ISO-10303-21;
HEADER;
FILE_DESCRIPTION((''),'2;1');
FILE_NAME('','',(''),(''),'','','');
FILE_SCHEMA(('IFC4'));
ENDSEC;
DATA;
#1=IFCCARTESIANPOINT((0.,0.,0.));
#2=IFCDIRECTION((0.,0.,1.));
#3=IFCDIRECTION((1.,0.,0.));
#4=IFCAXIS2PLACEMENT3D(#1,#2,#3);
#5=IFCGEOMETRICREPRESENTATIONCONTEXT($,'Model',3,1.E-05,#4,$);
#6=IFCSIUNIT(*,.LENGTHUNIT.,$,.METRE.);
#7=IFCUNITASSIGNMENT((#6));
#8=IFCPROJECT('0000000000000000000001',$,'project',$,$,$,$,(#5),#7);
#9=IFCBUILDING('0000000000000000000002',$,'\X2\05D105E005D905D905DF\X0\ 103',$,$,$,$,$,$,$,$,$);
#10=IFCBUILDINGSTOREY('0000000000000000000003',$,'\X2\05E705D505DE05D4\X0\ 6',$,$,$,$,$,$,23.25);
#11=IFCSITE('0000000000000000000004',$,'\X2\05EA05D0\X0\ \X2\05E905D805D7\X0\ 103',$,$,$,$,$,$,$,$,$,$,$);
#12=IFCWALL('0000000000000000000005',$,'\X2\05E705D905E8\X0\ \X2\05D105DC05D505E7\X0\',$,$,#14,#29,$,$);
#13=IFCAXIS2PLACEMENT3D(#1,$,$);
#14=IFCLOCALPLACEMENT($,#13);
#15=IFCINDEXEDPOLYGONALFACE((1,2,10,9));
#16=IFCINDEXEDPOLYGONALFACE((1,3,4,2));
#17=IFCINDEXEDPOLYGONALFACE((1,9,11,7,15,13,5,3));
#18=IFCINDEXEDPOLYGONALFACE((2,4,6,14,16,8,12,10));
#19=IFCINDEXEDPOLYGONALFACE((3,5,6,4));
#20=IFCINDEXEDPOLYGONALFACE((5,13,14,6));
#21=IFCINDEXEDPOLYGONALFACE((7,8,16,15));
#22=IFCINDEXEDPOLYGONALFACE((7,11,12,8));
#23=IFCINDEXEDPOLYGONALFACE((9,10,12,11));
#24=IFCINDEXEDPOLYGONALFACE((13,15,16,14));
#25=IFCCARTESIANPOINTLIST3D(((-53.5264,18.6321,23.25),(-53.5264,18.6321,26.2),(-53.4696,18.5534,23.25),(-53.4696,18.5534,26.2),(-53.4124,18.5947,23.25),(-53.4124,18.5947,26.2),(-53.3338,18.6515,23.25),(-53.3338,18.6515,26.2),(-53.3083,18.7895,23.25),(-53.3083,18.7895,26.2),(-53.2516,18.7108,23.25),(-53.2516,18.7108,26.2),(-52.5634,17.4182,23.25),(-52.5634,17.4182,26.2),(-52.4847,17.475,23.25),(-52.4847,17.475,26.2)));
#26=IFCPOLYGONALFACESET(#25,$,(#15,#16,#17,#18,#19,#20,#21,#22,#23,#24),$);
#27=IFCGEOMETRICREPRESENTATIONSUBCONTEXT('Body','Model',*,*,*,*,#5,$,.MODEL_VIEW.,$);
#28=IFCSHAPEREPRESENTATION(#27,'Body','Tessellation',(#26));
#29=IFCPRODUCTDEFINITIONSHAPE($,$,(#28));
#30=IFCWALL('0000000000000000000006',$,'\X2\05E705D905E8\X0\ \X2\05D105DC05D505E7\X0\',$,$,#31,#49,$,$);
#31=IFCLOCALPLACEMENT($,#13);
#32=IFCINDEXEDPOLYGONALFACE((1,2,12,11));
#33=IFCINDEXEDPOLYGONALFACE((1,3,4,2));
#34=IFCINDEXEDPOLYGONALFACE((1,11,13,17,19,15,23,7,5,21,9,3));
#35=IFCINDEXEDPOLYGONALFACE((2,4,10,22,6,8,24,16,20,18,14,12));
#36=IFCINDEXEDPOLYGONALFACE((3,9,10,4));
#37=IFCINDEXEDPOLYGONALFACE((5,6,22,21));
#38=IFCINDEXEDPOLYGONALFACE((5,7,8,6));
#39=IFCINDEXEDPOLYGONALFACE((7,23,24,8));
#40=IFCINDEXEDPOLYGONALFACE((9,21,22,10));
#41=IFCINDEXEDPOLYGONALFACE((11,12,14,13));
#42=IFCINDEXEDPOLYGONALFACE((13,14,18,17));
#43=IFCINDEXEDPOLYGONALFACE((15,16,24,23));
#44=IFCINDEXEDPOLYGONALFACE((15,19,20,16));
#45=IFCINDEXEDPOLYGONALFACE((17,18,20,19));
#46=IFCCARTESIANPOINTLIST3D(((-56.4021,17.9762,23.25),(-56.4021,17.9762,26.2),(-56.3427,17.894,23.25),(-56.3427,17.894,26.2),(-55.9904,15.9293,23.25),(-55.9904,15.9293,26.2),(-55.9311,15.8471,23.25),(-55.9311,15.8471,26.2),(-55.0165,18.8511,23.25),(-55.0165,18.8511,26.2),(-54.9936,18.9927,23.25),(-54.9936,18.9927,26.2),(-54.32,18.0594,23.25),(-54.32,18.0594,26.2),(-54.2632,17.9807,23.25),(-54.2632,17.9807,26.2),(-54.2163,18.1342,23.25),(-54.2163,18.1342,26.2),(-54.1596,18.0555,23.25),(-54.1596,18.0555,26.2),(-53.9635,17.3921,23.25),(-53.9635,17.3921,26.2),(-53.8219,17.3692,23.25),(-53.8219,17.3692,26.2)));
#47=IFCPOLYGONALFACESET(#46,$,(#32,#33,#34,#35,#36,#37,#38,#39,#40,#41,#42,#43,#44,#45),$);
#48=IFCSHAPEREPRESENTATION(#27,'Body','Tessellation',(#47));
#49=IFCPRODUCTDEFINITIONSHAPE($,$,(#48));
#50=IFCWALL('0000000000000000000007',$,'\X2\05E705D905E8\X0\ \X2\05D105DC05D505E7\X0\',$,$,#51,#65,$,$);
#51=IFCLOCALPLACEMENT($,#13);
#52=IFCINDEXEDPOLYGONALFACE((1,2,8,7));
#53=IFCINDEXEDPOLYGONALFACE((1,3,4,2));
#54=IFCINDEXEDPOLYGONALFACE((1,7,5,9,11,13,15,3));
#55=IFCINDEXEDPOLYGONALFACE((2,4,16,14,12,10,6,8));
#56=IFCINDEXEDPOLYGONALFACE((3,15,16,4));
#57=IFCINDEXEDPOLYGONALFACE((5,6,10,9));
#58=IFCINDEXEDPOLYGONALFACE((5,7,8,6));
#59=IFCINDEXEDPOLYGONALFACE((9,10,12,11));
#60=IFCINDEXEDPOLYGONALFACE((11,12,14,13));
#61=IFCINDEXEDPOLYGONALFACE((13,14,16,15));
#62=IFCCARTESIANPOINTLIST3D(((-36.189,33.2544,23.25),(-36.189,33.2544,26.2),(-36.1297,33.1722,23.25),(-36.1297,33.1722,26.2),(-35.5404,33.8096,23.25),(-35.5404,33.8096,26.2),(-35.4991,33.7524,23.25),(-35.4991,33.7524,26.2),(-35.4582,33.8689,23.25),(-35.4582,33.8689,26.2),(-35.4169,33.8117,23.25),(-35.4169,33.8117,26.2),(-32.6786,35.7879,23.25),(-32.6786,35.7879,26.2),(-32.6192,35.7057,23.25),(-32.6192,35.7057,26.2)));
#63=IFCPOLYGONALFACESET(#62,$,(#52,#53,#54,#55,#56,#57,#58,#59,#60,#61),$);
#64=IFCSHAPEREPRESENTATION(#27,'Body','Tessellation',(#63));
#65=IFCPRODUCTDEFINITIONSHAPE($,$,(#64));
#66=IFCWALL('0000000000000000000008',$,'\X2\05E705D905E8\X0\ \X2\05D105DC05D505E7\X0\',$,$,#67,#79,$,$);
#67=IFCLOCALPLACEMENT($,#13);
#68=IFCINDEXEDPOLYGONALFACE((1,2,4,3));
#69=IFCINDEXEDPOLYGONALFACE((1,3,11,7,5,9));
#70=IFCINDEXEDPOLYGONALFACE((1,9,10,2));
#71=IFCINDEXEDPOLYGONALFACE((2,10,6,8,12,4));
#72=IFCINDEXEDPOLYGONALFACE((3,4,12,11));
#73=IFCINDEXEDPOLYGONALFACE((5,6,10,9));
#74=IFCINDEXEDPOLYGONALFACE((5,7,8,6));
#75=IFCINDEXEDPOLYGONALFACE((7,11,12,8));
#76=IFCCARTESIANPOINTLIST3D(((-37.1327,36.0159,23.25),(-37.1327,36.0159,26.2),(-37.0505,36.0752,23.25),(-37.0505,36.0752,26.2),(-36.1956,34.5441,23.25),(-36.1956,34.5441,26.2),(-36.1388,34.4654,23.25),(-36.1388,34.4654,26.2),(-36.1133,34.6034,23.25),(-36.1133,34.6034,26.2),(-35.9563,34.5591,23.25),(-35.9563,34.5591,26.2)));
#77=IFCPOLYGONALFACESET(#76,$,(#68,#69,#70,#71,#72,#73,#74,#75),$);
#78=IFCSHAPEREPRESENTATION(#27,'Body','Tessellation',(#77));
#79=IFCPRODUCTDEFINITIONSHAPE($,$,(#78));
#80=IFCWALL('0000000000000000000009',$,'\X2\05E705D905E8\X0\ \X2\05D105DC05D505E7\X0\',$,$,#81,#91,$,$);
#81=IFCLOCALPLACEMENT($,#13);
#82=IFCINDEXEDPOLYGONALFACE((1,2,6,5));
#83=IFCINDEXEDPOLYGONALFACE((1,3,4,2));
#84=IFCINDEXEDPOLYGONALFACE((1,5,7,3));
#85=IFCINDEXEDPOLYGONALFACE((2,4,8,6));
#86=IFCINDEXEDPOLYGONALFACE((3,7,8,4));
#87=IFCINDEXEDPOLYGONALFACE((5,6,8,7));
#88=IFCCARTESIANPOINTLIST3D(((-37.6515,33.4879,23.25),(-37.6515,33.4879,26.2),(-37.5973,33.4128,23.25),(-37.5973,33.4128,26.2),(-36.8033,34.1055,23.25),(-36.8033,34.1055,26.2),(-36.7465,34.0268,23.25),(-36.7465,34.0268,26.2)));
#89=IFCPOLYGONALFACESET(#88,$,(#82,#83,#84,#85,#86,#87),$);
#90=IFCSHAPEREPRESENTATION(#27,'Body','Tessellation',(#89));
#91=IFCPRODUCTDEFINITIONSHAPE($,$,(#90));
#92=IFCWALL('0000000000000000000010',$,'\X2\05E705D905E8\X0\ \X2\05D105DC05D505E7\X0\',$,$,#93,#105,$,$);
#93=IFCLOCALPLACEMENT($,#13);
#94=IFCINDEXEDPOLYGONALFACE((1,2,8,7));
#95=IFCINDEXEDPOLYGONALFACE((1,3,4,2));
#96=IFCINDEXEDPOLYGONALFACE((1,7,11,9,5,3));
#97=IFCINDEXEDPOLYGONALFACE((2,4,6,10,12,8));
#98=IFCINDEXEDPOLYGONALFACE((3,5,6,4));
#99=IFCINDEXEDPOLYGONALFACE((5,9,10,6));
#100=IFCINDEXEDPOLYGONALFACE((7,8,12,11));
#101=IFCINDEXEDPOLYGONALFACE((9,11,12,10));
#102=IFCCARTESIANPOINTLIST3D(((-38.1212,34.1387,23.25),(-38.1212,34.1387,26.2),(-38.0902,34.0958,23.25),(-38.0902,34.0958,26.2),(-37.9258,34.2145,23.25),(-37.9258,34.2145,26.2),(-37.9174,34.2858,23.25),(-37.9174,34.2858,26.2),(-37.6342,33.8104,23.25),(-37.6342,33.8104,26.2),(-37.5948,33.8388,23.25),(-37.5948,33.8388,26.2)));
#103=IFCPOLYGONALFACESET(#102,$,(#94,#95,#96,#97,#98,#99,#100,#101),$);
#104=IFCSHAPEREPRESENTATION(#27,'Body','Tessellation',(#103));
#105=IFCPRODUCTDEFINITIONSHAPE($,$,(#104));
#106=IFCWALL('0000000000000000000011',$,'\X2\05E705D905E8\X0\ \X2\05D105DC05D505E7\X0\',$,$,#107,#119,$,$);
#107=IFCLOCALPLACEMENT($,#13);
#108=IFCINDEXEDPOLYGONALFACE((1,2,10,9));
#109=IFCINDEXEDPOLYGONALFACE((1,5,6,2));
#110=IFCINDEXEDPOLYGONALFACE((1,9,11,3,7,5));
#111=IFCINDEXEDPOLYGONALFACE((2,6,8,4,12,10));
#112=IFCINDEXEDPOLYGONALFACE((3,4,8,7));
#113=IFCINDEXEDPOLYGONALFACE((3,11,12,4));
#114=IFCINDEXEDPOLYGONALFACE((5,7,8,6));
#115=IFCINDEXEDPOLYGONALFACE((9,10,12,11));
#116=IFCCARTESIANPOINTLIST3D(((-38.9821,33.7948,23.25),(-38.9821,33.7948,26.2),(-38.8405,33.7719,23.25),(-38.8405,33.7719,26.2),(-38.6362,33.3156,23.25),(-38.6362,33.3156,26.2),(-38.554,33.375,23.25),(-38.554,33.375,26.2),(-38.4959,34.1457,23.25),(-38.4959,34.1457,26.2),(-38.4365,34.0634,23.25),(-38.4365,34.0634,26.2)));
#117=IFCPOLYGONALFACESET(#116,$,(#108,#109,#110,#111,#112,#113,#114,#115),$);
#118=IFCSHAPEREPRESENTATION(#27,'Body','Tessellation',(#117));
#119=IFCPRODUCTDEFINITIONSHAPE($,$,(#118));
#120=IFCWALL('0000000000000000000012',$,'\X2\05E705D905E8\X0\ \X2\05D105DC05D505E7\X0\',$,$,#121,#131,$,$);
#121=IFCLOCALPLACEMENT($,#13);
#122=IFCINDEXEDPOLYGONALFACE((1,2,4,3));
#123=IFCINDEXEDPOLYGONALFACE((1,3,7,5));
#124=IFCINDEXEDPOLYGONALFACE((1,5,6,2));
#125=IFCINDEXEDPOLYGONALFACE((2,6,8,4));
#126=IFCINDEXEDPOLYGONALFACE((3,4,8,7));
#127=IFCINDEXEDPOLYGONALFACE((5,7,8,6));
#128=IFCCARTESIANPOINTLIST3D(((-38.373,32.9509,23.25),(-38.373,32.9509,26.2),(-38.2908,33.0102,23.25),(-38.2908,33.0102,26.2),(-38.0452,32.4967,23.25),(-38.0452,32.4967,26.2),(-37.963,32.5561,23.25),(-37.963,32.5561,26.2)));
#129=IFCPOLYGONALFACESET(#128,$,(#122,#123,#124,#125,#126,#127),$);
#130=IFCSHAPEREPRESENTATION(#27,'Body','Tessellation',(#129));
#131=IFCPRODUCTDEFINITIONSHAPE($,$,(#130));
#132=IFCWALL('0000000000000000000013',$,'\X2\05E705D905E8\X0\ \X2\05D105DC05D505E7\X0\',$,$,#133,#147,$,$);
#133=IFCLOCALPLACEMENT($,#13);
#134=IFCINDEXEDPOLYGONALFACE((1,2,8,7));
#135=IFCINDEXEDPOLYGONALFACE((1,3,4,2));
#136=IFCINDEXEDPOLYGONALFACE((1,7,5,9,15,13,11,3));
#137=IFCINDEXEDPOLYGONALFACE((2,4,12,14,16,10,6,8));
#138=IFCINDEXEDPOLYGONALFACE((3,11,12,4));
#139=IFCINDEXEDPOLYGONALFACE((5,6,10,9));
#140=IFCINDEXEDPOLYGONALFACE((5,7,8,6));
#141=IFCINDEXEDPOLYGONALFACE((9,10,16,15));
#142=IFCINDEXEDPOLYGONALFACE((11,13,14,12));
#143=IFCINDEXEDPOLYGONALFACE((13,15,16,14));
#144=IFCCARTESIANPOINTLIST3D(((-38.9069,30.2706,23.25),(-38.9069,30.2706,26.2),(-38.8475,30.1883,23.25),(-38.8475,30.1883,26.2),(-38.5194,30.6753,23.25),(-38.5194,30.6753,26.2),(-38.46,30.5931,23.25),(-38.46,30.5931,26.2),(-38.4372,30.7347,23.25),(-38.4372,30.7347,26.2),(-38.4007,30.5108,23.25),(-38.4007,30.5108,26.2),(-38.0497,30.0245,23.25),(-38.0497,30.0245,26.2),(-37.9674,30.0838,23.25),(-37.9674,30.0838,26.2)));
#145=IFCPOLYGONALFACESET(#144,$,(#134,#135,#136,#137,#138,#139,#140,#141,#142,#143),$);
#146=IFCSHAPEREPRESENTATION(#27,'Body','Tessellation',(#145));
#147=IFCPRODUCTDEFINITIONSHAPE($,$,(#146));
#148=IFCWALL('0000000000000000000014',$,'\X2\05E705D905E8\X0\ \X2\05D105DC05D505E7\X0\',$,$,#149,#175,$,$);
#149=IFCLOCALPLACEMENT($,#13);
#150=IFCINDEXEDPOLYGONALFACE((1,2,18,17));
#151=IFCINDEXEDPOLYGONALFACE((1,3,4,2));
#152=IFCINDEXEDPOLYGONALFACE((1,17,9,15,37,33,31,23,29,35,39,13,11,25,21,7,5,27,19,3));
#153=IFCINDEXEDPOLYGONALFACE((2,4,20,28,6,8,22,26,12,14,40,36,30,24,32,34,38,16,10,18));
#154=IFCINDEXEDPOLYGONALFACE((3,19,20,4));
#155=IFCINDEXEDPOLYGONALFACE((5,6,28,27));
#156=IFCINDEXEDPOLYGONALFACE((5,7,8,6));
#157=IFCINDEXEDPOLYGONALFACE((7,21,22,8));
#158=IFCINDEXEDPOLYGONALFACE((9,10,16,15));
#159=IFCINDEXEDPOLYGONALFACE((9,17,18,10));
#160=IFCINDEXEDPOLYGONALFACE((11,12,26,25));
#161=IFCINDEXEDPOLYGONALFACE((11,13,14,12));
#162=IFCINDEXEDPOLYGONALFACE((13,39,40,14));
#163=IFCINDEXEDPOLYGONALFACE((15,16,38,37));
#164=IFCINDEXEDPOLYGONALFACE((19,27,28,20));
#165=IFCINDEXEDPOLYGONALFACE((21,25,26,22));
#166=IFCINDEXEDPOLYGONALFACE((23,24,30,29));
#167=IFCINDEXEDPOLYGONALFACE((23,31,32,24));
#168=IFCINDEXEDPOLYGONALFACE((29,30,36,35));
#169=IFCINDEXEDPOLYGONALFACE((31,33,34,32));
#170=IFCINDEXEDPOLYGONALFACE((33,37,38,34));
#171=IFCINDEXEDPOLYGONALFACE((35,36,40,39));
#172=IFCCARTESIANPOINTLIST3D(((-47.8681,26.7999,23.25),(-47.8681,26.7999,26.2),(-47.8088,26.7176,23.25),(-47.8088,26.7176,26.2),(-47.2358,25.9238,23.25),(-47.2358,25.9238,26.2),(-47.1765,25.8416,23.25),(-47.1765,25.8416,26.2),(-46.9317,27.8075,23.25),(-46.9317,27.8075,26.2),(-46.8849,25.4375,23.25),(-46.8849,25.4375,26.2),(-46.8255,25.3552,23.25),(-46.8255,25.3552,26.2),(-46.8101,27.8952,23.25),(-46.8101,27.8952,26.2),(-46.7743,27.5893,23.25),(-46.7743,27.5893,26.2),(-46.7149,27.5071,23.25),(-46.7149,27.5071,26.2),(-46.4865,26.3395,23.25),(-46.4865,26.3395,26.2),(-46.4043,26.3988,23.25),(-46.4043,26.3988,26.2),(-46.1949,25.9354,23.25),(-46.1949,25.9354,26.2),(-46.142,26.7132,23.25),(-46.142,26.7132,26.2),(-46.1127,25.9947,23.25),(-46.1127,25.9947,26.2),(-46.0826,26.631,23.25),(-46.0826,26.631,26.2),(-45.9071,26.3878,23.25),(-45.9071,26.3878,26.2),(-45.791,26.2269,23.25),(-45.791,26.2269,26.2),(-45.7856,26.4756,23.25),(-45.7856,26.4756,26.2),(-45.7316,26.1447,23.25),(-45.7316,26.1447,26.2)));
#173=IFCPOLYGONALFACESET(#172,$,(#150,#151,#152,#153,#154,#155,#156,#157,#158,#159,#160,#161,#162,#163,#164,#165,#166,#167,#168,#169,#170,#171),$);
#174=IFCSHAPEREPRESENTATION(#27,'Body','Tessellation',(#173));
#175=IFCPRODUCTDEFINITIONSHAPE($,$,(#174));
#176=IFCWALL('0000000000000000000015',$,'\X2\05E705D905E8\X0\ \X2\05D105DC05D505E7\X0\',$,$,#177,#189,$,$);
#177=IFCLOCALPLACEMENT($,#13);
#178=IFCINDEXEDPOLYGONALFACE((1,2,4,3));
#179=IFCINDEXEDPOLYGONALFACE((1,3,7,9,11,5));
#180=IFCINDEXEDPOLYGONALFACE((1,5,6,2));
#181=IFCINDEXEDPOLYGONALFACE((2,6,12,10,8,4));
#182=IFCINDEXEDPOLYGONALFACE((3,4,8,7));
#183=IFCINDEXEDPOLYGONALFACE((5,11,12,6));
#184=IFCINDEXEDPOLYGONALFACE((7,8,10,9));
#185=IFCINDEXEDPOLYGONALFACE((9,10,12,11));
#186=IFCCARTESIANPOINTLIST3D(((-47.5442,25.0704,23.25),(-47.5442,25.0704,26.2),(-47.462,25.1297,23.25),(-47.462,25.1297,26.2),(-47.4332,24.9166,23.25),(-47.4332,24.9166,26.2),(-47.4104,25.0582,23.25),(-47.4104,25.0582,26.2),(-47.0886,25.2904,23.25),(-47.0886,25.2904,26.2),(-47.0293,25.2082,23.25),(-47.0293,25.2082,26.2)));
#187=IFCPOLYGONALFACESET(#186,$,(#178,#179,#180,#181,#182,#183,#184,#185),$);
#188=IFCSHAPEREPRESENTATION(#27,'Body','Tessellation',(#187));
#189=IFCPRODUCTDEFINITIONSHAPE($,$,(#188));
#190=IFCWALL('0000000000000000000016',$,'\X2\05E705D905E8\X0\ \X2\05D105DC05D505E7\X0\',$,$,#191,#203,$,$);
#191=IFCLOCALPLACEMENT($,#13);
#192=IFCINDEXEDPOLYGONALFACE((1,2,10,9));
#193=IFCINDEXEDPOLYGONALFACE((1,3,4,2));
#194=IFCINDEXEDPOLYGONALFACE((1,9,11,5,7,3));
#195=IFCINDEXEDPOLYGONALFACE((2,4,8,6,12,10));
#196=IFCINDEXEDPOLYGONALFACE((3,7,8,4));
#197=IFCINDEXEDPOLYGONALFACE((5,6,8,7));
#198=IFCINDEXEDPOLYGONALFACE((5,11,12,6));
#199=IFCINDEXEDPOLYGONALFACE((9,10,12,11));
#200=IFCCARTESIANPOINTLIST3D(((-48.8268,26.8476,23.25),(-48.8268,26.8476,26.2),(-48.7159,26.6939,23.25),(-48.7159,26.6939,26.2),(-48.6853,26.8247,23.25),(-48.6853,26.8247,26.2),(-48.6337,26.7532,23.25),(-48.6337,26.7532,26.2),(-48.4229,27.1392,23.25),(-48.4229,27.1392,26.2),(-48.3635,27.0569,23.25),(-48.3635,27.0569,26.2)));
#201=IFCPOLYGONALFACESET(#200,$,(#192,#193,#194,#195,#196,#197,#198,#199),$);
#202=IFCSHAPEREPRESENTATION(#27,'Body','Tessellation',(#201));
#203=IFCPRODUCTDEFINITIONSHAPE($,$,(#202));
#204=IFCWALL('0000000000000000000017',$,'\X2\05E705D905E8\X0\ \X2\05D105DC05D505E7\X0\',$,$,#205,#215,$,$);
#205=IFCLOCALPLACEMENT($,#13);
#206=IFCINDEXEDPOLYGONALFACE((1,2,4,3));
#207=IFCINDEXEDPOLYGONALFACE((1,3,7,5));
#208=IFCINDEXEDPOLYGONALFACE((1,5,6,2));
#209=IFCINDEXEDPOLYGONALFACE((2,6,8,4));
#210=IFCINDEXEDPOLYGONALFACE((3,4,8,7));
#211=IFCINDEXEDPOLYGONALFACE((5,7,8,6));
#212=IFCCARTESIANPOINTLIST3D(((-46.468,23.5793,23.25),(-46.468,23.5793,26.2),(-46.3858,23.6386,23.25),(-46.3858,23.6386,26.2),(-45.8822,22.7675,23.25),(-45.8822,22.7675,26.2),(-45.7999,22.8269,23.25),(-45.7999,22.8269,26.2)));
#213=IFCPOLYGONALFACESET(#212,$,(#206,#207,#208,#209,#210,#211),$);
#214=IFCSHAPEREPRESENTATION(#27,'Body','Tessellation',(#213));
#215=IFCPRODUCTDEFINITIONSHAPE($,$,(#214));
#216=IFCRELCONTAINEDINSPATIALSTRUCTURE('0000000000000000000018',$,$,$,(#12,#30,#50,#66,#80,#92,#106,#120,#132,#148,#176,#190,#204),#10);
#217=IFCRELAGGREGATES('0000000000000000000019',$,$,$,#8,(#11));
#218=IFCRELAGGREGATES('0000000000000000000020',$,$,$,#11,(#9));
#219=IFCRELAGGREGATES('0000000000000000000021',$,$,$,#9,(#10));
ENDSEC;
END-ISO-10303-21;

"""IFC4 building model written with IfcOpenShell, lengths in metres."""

from ifc_helpers import new_model, si_unit, frame, origin_with_axes, context, subcontext, project, spatial, polyline, outline, extrude, element, save


model = new_model("IFC4")

# Units and contexts
model_context = context("Model", 3, precision=1e-05, world=origin_with_axes())
body_context = subcontext(model_context, "Body", "Model", "MODEL_VIEW")
ifc_project = project(units=[si_unit("LENGTHUNIT", "METRE")], contexts=[model_context])

# Site, building, storey
site = spatial("IfcSite", under=ifc_project, Name="תא שטח 103")
building = spatial("IfcBuilding", under=site, Name="בניין 103")
storey = spatial("IfcBuildingStorey", under=building, Name="קומה 6", Elevation=23.25)

# Walls
element("IfcWall", 1, inside=storey, Name="קיר בלוק", context=body_context, shape_type="SweptSolid", body=[
    extrude(outline(polyline([(-52.5634, 17.4182), (-53.4124, 18.5947), (-53.4696, 18.5534), (-53.5264, 18.6321), (-53.3083, 18.7895), (-53.2516, 18.7108), (-53.3338, 18.6515), (-52.4847, 17.475), (-52.5634, 17.4182)])), frame((0.0, 0.0, 23.25)), (0.0, 0.0, 1.0), 2.95),
])
element("IfcWall", 2, inside=storey, Name="קיר בלוק", context=body_context, shape_type="SweptSolid", body=[
    extrude(outline(polyline([(-53.9635, 17.3921), (-55.0165, 18.8511), (-56.3427, 17.894), (-56.4021, 17.9762), (-54.9936, 18.9927), (-54.32, 18.0594), (-54.2163, 18.1342), (-54.1596, 18.0555), (-54.2632, 17.9807), (-53.8219, 17.3692), (-55.9311, 15.8471), (-55.9904, 15.9293), (-53.9635, 17.3921)])), frame((0.0, 0.0, 23.25)), (0.0, 0.0, 1.0), 2.95),
])
element("IfcWall", 3, inside=storey, Name="קיר בלוק", context=body_context, shape_type="SweptSolid", body=[
    extrude(outline(polyline([(-32.6192, 35.7057), (-36.1297, 33.1722), (-36.189, 33.2544), (-35.4991, 33.7524), (-35.5404, 33.8096), (-35.4582, 33.8689), (-35.4169, 33.8117), (-32.6786, 35.7879), (-32.6192, 35.7057)])), frame((0.0, 0.0, 23.25)), (0.0, 0.0, 1.0), 2.95),
])
element("IfcWall", 4, inside=storey, Name="קיר בלוק", context=body_context, shape_type="SweptSolid", body=[
    extrude(outline(polyline([(-36.1388, 34.4654), (-36.1956, 34.5441), (-36.1133, 34.6034), (-37.1327, 36.0159), (-37.0505, 36.0752), (-35.9563, 34.5591), (-36.1388, 34.4654)])), frame((0.0, 0.0, 23.25)), (0.0, 0.0, 1.0), 2.95),
])
element("IfcWall", 5, inside=storey, Name="קיר בלוק", context=body_context, shape_type="SweptSolid", body=[
    extrude(outline(polyline([(-37.5973, 33.4128), (-37.6515, 33.4879), (-36.8033, 34.1055), (-36.7465, 34.0268), (-37.5973, 33.4128)])), frame((0.0, 0.0, 23.25)), (0.0, 0.0, 1.0), 2.95),
])
element("IfcWall", 6, inside=storey, Name="קיר בלוק", context=body_context, shape_type="SweptSolid", body=[
    extrude(outline(polyline([(-37.6342, 33.8104), (-37.9258, 34.2145), (-38.0902, 34.0958), (-38.1212, 34.1387), (-37.9174, 34.2858), (-37.5948, 33.8388), (-37.6342, 33.8104)])), frame((0.0, 0.0, 23.25)), (0.0, 0.0, 1.0), 2.95),
])
element("IfcWall", 7, inside=storey, Name="קיר בלוק", context=body_context, shape_type="SweptSolid", body=[
    extrude(outline(polyline([(-38.9821, 33.7948), (-38.4959, 34.1457), (-38.4365, 34.0634), (-38.8405, 33.7719), (-38.554, 33.375), (-38.6362, 33.3156), (-38.9821, 33.7948)])), frame((0.0, 0.0, 23.25)), (0.0, 0.0, 1.0), 2.95),
])
element("IfcWall", 8, inside=storey, Name="קיר בלוק", context=body_context, shape_type="SweptSolid", body=[
    extrude(outline(polyline([(-38.2908, 33.0102), (-37.963, 32.5561), (-38.0452, 32.4967), (-38.373, 32.9509), (-38.2908, 33.0102)])), frame((0.0, 0.0, 23.25)), (0.0, 0.0, 1.0), 2.95),
])
element("IfcWall", 9, inside=storey, Name="קיר בלוק", context=body_context, shape_type="SweptSolid", body=[
    extrude(outline(polyline([(-38.9069, 30.2706), (-38.46, 30.5931), (-38.5194, 30.6753), (-38.4372, 30.7347), (-37.9674, 30.0838), (-38.0497, 30.0245), (-38.4007, 30.5108), (-38.8475, 30.1883), (-38.9069, 30.2706)])), frame((0.0, 0.0, 23.25)), (0.0, 0.0, 1.0), 2.95),
])
element("IfcWall", 10, inside=storey, Name="קיר בלוק", context=body_context, shape_type="SweptSolid", body=[
    extrude(outline(polyline([(-46.1127, 25.9947), (-45.791, 26.2269), (-45.7316, 26.1447), (-46.8255, 25.3552), (-46.8849, 25.4375), (-46.1949, 25.9354), (-46.4865, 26.3395), (-47.1765, 25.8416), (-47.2358, 25.9238), (-46.142, 26.7132), (-46.7149, 27.5071), (-47.8088, 26.7176), (-47.8681, 26.7999), (-46.7743, 27.5893), (-46.9317, 27.8075), (-46.8101, 27.8952), (-45.7856, 26.4756), (-45.9071, 26.3878), (-46.0826, 26.631), (-46.4043, 26.3988), (-46.1127, 25.9947)])), frame((0.0, 0.0, 23.25)), (0.0, 0.0, 1.0), 2.95),
])
element("IfcWall", 11, inside=storey, Name="קיר בלוק", context=body_context, shape_type="SweptSolid", body=[
    extrude(outline(polyline([(-47.462, 25.1297), (-47.4104, 25.0582), (-47.0886, 25.2904), (-47.0293, 25.2082), (-47.4332, 24.9166), (-47.5442, 25.0704), (-47.462, 25.1297)])), frame((0.0, 0.0, 23.25)), (0.0, 0.0, 1.0), 2.95),
])
element("IfcWall", 12, inside=storey, Name="קיר בלוק", context=body_context, shape_type="SweptSolid", body=[
    extrude(outline(polyline([(-48.6337, 26.7532), (-48.7159, 26.6939), (-48.8268, 26.8476), (-48.4229, 27.1392), (-48.3635, 27.0569), (-48.6853, 26.8247), (-48.6337, 26.7532)])), frame((0.0, 0.0, 23.25)), (0.0, 0.0, 1.0), 2.95),
])
element("IfcWall", 13, inside=storey, Name="קיר בלוק", context=body_context, shape_type="SweptSolid", body=[
    extrude(outline(polyline([(-45.7999, 22.8269), (-45.8822, 22.7675), (-46.468, 23.5793), (-46.3858, 23.6386), (-45.7999, 22.8269)])), frame((0.0, 0.0, 23.25)), (0.0, 0.0, 1.0), 2.95),
])

save(model, "model.ifc")
